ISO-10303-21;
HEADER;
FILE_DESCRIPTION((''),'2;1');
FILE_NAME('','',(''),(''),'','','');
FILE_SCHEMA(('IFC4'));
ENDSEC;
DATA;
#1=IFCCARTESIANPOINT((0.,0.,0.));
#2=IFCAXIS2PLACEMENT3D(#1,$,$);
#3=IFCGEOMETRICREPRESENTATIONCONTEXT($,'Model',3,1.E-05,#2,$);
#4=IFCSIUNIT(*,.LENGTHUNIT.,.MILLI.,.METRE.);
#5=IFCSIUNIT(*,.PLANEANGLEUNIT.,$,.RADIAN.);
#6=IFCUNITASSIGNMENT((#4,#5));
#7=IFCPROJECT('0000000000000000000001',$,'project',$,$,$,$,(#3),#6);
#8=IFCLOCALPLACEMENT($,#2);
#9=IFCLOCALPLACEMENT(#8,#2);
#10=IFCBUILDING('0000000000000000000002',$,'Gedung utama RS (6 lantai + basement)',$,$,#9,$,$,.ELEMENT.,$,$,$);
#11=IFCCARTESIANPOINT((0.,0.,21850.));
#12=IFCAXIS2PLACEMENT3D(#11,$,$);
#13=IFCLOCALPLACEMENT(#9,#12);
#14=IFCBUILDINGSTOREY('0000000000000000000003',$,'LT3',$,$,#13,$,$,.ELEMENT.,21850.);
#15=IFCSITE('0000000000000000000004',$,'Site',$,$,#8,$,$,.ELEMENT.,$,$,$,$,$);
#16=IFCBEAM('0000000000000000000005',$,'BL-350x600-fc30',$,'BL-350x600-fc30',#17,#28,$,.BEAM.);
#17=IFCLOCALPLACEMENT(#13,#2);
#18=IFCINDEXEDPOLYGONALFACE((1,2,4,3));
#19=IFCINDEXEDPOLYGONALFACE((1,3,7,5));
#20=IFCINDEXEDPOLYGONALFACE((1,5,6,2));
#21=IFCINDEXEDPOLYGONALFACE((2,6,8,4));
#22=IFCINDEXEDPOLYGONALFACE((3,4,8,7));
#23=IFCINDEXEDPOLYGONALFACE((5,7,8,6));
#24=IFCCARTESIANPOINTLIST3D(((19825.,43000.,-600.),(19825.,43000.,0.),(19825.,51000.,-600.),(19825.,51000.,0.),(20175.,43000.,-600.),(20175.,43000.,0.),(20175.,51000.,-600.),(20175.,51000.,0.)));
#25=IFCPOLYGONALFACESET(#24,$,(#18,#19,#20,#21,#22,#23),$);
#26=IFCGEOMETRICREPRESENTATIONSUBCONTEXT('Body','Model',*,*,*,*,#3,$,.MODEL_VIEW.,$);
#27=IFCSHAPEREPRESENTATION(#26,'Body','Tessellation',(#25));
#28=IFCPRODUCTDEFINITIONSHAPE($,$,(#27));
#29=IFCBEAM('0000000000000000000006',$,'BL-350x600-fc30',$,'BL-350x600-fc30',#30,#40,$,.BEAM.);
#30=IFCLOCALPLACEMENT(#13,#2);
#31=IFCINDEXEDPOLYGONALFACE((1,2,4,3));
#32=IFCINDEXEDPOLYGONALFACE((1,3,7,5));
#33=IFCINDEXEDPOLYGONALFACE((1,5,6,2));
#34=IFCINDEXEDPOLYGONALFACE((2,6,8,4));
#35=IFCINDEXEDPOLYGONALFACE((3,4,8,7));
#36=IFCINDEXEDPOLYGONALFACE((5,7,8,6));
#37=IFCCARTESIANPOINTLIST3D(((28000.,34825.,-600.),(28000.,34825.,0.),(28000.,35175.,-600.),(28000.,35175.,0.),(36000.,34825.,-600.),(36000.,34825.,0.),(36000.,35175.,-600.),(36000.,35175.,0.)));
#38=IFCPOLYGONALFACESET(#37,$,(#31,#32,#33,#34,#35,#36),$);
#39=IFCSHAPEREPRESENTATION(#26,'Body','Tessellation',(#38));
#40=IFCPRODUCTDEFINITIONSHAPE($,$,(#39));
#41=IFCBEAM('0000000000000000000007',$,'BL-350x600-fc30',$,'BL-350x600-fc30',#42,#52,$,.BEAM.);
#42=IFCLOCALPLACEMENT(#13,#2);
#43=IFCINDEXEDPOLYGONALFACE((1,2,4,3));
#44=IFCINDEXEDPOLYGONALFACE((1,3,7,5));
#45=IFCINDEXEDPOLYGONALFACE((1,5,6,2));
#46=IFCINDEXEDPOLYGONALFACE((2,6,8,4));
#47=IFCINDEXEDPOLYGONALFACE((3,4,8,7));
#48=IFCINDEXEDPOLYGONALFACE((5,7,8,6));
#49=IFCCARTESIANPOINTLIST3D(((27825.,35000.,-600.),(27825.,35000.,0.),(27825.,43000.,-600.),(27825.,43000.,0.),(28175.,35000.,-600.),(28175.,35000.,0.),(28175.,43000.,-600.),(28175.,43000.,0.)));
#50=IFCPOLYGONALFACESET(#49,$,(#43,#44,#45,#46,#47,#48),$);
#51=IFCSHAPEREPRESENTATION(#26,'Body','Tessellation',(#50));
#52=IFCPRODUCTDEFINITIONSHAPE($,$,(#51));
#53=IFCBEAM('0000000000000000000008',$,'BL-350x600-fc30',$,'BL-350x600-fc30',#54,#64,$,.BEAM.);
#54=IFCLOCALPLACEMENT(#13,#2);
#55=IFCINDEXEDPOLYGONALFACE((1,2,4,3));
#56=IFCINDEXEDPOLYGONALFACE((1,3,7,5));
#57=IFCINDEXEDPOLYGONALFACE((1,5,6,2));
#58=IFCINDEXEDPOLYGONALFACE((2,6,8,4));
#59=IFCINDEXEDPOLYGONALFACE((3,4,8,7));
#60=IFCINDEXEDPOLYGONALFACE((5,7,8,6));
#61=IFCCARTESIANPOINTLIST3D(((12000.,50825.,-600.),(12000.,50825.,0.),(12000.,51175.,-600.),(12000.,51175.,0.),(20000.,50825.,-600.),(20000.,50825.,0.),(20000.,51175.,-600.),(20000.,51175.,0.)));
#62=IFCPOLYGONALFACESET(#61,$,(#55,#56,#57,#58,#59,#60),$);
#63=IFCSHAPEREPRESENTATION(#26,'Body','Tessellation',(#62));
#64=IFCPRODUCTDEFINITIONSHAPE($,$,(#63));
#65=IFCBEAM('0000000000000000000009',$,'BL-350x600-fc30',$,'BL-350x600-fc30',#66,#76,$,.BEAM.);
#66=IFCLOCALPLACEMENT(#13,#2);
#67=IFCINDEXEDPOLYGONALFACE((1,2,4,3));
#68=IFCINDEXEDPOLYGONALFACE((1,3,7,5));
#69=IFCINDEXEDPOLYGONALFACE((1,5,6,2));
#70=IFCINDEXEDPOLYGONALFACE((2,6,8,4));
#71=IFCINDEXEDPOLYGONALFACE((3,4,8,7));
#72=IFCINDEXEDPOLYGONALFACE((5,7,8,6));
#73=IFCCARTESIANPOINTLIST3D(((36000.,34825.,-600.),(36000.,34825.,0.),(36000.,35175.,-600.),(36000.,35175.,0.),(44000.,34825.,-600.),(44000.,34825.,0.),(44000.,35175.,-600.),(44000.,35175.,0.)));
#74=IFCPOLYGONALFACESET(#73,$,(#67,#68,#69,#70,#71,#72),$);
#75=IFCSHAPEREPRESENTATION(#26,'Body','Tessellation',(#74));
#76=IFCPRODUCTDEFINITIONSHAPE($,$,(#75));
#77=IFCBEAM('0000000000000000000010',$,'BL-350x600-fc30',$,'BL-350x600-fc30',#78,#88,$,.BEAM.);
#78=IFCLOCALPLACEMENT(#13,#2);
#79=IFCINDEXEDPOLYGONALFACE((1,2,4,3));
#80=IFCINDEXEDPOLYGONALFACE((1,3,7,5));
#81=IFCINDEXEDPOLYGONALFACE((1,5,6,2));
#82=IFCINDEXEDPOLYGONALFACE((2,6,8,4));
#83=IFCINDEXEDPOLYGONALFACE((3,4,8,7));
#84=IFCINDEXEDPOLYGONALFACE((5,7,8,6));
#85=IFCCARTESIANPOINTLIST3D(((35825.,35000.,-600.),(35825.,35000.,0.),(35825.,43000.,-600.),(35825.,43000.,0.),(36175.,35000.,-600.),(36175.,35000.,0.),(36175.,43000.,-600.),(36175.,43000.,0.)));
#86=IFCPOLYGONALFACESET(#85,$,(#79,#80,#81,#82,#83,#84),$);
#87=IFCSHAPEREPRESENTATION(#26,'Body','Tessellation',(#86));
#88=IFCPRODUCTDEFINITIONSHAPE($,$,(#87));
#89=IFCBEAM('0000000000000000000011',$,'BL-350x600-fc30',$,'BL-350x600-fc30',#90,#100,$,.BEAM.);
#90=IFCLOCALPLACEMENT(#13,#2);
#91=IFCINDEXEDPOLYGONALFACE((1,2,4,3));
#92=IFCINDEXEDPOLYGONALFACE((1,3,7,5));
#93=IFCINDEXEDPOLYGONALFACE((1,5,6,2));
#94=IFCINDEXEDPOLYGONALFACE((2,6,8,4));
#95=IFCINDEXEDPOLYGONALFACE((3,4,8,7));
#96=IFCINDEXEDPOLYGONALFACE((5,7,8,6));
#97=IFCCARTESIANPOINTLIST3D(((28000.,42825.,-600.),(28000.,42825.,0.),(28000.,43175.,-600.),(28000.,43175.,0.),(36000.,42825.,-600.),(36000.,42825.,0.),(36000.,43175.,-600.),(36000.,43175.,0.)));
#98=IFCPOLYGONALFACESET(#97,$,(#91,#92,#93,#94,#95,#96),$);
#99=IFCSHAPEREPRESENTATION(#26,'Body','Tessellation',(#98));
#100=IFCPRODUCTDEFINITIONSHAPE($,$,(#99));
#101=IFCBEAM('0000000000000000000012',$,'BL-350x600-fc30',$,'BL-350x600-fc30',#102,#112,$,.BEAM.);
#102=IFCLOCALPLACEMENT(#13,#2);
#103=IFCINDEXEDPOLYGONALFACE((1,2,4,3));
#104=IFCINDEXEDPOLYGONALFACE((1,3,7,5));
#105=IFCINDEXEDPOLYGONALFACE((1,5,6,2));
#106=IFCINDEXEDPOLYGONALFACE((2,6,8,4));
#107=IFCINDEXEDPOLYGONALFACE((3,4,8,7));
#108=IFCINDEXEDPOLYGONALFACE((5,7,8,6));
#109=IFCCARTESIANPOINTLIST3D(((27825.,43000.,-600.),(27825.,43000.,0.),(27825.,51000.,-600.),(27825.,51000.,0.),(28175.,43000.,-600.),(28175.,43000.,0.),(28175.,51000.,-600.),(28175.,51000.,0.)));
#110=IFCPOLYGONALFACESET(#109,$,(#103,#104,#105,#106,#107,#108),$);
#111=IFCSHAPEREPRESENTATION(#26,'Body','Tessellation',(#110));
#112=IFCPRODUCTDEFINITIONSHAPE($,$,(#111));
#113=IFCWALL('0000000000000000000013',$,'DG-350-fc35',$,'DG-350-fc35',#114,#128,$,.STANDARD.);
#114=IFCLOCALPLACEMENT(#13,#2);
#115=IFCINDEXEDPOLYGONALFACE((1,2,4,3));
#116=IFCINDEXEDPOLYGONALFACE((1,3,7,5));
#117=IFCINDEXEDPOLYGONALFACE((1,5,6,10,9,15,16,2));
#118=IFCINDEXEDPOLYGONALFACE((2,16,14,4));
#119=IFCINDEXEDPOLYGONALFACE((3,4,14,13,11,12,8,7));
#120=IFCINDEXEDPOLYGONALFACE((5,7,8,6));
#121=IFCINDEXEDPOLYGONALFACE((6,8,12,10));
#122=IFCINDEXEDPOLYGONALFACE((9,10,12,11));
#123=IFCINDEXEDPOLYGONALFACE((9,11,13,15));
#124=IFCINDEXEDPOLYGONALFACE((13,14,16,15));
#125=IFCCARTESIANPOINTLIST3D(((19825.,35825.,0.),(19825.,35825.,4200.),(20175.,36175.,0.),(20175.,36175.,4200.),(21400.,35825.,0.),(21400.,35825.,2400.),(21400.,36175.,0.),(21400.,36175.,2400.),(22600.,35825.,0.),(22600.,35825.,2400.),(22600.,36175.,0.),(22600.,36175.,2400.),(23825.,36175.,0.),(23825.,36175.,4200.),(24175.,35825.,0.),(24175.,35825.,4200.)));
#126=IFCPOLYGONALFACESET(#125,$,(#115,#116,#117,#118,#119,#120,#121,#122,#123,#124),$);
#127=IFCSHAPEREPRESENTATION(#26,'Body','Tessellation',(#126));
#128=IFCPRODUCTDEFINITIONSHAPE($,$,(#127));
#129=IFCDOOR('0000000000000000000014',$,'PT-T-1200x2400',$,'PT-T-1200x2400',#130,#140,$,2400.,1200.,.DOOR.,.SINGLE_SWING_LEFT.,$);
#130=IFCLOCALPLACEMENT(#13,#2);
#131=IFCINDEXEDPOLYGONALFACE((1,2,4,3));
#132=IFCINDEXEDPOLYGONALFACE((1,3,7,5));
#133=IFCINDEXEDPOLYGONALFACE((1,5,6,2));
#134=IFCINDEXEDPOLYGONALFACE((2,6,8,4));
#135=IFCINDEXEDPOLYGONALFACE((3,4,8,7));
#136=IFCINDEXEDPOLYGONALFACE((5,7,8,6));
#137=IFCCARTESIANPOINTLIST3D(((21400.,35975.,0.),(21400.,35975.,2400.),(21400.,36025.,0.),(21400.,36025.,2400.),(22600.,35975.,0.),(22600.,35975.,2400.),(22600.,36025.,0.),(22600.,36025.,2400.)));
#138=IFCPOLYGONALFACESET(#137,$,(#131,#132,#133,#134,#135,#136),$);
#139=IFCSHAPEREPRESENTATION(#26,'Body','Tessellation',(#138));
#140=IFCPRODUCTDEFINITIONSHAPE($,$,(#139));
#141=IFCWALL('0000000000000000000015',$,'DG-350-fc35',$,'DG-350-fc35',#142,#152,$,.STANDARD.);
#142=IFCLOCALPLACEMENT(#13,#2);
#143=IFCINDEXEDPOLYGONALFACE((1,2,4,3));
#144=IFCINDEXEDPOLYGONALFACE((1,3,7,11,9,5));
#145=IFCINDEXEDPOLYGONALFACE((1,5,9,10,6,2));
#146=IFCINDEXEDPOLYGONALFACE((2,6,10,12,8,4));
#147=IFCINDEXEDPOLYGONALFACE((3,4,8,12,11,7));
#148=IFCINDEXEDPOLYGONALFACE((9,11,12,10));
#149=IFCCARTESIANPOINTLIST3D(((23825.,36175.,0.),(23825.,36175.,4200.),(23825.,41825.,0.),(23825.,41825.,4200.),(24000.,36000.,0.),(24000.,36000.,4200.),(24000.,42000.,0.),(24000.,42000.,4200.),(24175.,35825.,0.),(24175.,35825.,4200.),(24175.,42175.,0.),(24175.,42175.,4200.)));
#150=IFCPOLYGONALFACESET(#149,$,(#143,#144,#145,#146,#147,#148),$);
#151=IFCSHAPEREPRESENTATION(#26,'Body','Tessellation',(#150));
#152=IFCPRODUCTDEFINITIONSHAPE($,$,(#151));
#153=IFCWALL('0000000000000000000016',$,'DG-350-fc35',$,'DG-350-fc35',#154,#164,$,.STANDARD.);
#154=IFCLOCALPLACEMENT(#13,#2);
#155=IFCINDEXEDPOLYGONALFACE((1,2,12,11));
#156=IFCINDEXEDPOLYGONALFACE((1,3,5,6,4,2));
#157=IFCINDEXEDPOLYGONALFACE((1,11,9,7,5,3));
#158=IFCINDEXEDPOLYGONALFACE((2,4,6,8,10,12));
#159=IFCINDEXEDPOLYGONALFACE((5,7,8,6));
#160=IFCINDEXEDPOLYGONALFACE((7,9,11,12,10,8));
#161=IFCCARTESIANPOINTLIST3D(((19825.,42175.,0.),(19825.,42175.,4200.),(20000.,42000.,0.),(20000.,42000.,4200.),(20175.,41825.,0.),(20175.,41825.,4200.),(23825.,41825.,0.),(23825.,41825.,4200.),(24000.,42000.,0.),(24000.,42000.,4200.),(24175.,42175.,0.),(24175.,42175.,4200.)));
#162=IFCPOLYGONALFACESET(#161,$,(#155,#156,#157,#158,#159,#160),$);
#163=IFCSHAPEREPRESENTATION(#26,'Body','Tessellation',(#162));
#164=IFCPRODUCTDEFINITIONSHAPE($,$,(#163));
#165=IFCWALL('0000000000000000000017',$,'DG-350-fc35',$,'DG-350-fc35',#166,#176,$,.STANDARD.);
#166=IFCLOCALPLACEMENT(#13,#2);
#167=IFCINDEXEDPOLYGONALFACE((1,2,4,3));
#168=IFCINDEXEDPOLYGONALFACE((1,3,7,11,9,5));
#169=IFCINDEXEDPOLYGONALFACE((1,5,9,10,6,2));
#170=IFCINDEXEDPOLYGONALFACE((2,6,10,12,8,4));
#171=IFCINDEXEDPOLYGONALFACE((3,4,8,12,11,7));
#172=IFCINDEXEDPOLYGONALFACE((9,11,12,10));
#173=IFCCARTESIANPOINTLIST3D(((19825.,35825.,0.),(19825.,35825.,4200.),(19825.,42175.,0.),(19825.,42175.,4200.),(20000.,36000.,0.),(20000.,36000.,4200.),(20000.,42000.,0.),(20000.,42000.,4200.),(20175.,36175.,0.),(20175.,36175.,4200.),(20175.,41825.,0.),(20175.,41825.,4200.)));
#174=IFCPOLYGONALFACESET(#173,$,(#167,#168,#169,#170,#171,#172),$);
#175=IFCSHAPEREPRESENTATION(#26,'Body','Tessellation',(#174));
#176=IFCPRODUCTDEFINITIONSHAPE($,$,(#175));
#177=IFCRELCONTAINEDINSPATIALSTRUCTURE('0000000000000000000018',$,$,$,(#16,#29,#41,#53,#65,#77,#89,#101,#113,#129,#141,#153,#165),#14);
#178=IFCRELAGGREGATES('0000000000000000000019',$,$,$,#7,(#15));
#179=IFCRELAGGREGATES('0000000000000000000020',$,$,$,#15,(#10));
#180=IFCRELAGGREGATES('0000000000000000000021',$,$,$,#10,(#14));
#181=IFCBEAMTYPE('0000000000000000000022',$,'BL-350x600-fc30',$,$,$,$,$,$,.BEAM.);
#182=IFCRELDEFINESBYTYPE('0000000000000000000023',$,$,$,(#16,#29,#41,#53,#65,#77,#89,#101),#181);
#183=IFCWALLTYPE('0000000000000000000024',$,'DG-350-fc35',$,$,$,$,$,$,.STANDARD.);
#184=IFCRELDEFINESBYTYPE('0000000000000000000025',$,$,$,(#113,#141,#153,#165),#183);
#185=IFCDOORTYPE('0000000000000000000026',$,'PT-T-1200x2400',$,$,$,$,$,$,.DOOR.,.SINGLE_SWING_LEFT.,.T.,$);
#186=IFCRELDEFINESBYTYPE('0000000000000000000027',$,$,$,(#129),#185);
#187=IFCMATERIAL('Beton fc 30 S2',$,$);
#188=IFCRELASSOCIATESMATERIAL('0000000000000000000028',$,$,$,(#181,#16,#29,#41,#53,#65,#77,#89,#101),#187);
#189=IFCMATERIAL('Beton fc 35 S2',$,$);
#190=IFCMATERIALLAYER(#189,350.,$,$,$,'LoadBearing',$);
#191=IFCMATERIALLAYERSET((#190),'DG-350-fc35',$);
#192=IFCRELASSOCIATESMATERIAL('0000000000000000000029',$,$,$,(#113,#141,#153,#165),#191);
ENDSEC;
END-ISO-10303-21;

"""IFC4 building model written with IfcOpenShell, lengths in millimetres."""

from ifc_helpers import new_model, si_unit, frame, frame_2d, origin, origin_2d, place, context, subcontext, project, spatial, polyline, rectangle, outline, extrude, material, layer, layer_set, layer_usage, material_profile, profile_set, profile_usage, type_object, element, fill, save


model = new_model("IFC4")

# Units and contexts
model_context = context("Model", 3, precision=1e-05, world=origin())
body_context = subcontext(model_context, "Body", "Model", "MODEL_VIEW")
ifc_project = project(units=[si_unit("LENGTHUNIT", "METRE", prefix="MILLI"), si_unit("PLANEANGLEUNIT", "RADIAN")], contexts=[model_context])

# Site, building, storey
site_placement = place(None, origin())
site = spatial("IfcSite", under=ifc_project, at=site_placement, Name="Site", CompositionType="ELEMENT")
building_placement = place(site_placement, origin())
building = spatial("IfcBuilding", under=site, at=building_placement, Name="Gedung utama RS (6 lantai + basement)", CompositionType="ELEMENT")
storey_placement = place(building_placement, frame((0.0, 0.0, 21850.0)))
storey = spatial("IfcBuildingStorey", under=building, at=storey_placement, Name="LT3", CompositionType="ELEMENT", Elevation=21850.0)

# Beams
ifc_material_1 = material(Name="Beton fc 30 S2")
ifc_material_profile_1 = material_profile(ifc_material_1, rectangle(XDim=350.0, YDim=600.0, at=origin_2d()), Name="BL-350x600-fc30")
ifc_profile_set_1 = profile_set([ifc_material_profile_1], Name="BL-350x600-fc30")
ifc_profile_usage_1 = profile_usage(ifc_profile_set_1, cardinal=8)
beam_type = type_object("IfcBeamType", Name="BL-350x600-fc30", PredefinedType="BEAM", material=ifc_profile_set_1)
beam_1_placement = place(storey_placement, frame((20000.0, 43000.0, -300.0)))
element("IfcBeam", 1, at=beam_1_placement, inside=storey, type_object=beam_type, material=ifc_profile_usage_1, Name="BL-350x600-fc30", ObjectType="BL-350x600-fc30", PredefinedType="BEAM", context=body_context, shape_type="SweptSolid", body=[
    extrude(rectangle(XDim=350.0, YDim=600.0, at=origin_2d()), frame((0.0, 0.0, 0.0), z_axis=(0.0, 1.0, 0.0), x_axis=(-1.0, 0.0, 0.0)), (0.0, 0.0, 1.0), 8000.0),
])
beam_2_placement = place(storey_placement, frame((28000.0, 35000.0, -300.0)))
element("IfcBeam", 2, at=beam_2_placement, inside=storey, type_object=beam_type, material=ifc_profile_usage_1, Name="BL-350x600-fc30", ObjectType="BL-350x600-fc30", PredefinedType="BEAM", context=body_context, shape_type="SweptSolid", body=[
    extrude(rectangle(XDim=350.0, YDim=600.0, at=origin_2d()), frame((0.0, 0.0, 0.0), z_axis=(1.0, 0.0, 0.0), x_axis=(0.0, 1.0, 0.0)), (0.0, 0.0, 1.0), 8000.0),
])
beam_3_placement = place(storey_placement, frame((28000.0, 35000.0, -300.0)))
element("IfcBeam", 3, at=beam_3_placement, inside=storey, type_object=beam_type, material=ifc_profile_usage_1, Name="BL-350x600-fc30", ObjectType="BL-350x600-fc30", PredefinedType="BEAM", context=body_context, shape_type="SweptSolid", body=[
    extrude(rectangle(XDim=350.0, YDim=600.0, at=origin_2d()), frame((0.0, 0.0, 0.0), z_axis=(0.0, 1.0, 0.0), x_axis=(-1.0, 0.0, 0.0)), (0.0, 0.0, 1.0), 8000.0),
])
for number, where, name in (
    (4, (12000.0, 51000.0, -300.0), "BL-350x600-fc30"),
    (5, (36000.0, 35000.0, -300.0), "BL-350x600-fc30"),
):
    element("IfcBeam", number, at=place(storey_placement, frame(where)), inside=storey, type_object=beam_type, material=ifc_profile_usage_1, Name=name, ObjectType="BL-350x600-fc30", PredefinedType="BEAM", context=body_context, shape_type="SweptSolid", body=[
        extrude(rectangle(XDim=350.0, YDim=600.0, at=origin_2d()), frame((0.0, 0.0, 0.0), z_axis=(1.0, 0.0, 0.0), x_axis=(0.0, 1.0, 0.0)), (0.0, 0.0, 1.0), 8000.0),
    ])
beam_4_placement = place(storey_placement, frame((36000.0, 35000.0, -300.0)))
element("IfcBeam", 6, at=beam_4_placement, inside=storey, type_object=beam_type, material=ifc_profile_usage_1, Name="BL-350x600-fc30", ObjectType="BL-350x600-fc30", PredefinedType="BEAM", context=body_context, shape_type="SweptSolid", body=[
    extrude(rectangle(XDim=350.0, YDim=600.0, at=origin_2d()), frame((0.0, 0.0, 0.0), z_axis=(0.0, 1.0, 0.0), x_axis=(-1.0, 0.0, 0.0)), (0.0, 0.0, 1.0), 8000.0),
])
beam_5_placement = place(storey_placement, frame((28000.0, 43000.0, -300.0)))
element("IfcBeam", 7, at=beam_5_placement, inside=storey, type_object=beam_type, material=ifc_profile_usage_1, Name="BL-350x600-fc30", ObjectType="BL-350x600-fc30", PredefinedType="BEAM", context=body_context, shape_type="SweptSolid", body=[
    extrude(rectangle(XDim=350.0, YDim=600.0, at=origin_2d()), frame((0.0, 0.0, 0.0), z_axis=(1.0, 0.0, 0.0), x_axis=(0.0, 1.0, 0.0)), (0.0, 0.0, 1.0), 8000.0),
])
beam_6_placement = place(storey_placement, frame((28000.0, 43000.0, -300.0)))
element("IfcBeam", 8, at=beam_6_placement, inside=storey, type_object=beam_type, material=ifc_profile_usage_1, Name="BL-350x600-fc30", ObjectType="BL-350x600-fc30", PredefinedType="BEAM", context=body_context, shape_type="SweptSolid", body=[
    extrude(rectangle(XDim=350.0, YDim=600.0, at=origin_2d()), frame((0.0, 0.0, 0.0), z_axis=(0.0, 1.0, 0.0), x_axis=(-1.0, 0.0, 0.0)), (0.0, 0.0, 1.0), 8000.0),
])

# Wall, opening, door
ifc_material_2 = material(Name="Beton fc 35 S2")
ifc_layer = layer(ifc_material_2, 350.0, Category="LoadBearing")
ifc_layer_set = layer_set([ifc_layer], Name="DG-350-fc35")
ifc_layer_usage = layer_usage(ifc_layer_set, "AXIS2", "NEGATIVE", 175.0)
wall_type = type_object("IfcWallType", Name="DG-350-fc35", PredefinedType="STANDARD")
wall_1_placement = place(storey_placement, frame((20000.0, 36000.0, 0.0), z_axis=(0.0, 0.0, 1.0), x_axis=(1.0, 0.0, 0.0)))
wall_1 = element("IfcWall", 9, at=wall_1_placement, inside=storey, type_object=wall_type, material=ifc_layer_usage, Name="DG-350-fc35", ObjectType="DG-350-fc35", PredefinedType="STANDARD", context=body_context, shape_type="SweptSolid", body=[
    extrude(outline(polyline([(-175.0, -175.0), (0.0, 0.0), (175.0, 175.0), (3825.0, 175.0), (4000.0, 0.0), (4175.0, -175.0), (-175.0, -175.0)])), origin(), (0.0, 0.0, 1.0), 4200.0),
])
opening_placement = place(wall_1_placement, frame((1400.0, 0.0, 0.0), z_axis=(0.0, 0.0, 1.0), x_axis=(1.0, 0.0, 0.0)))
opening = element("IfcOpeningElement", 10, at=opening_placement, cuts=wall_1, PredefinedType="OPENING", context=body_context, shape_type="SweptSolid", body=[
    extrude(rectangle(XDim=1200.0, YDim=370.0, at=frame_2d((600.0, 0.0))), origin(), (0.0, 0.0, 1.0), 2400.0),
])
door_type = type_object("IfcDoorType", Name="PT-T-1200x2400", OperationType="SINGLE_SWING_LEFT", ParameterTakesPrecedence=True, PredefinedType="DOOR")
door_placement = place(opening_placement, origin())
door = element("IfcDoor", 11, at=door_placement, inside=storey, type_object=door_type, Name="PT-T-1200x2400", ObjectType="PT-T-1200x2400", OperationType="SINGLE_SWING_LEFT", OverallHeight=2400.0, OverallWidth=1200.0, PredefinedType="DOOR", context=body_context, shape_type="SweptSolid", body=[
    extrude(rectangle(XDim=1200.0, YDim=50.0, at=frame_2d((600.0, 0.0))), origin(), (0.0, 0.0, 1.0), 2400.0),
])
fill(opening, door)

# Walls
wall_2_placement = place(storey_placement, frame((24000.0, 36000.0, 0.0), z_axis=(0.0, 0.0, 1.0), x_axis=(0.0, 1.0, 0.0)))
element("IfcWall", 12, at=wall_2_placement, inside=storey, type_object=wall_type, material=ifc_layer_usage, Name="DG-350-fc35", ObjectType="DG-350-fc35", PredefinedType="STANDARD", context=body_context, shape_type="SweptSolid", body=[
    extrude(outline(polyline([(-175.0, -175.0), (0.0, 0.0), (175.0, 175.0), (5825.0, 175.0), (6000.0, 0.0), (6175.0, -175.0), (-175.0, -175.0)])), origin(), (0.0, 0.0, 1.0), 4200.0),
])
wall_3_placement = place(storey_placement, frame((24000.0, 42000.0, 0.0), z_axis=(0.0, 0.0, 1.0), x_axis=(-1.0, 0.0, 0.0)))
element("IfcWall", 13, at=wall_3_placement, inside=storey, type_object=wall_type, material=ifc_layer_usage, Name="DG-350-fc35", ObjectType="DG-350-fc35", PredefinedType="STANDARD", context=body_context, shape_type="SweptSolid", body=[
    extrude(outline(polyline([(-175.0, -175.0), (0.0, 0.0), (175.0, 175.0), (3825.0, 175.0), (4000.0, 0.0), (4175.0, -175.0), (-175.0, -175.0)])), origin(), (0.0, 0.0, 1.0), 4200.0),
])
wall_4_placement = place(storey_placement, frame((20000.0, 42000.0, 0.0), z_axis=(0.0, 0.0, 1.0), x_axis=(0.0, -1.0, 0.0)))
element("IfcWall", 14, at=wall_4_placement, inside=storey, type_object=wall_type, material=ifc_layer_usage, Name="DG-350-fc35", ObjectType="DG-350-fc35", PredefinedType="STANDARD", context=body_context, shape_type="SweptSolid", body=[
    extrude(outline(polyline([(-175.0, -175.0), (0.0, 0.0), (175.0, 175.0), (5825.0, 175.0), (6000.0, 0.0), (6175.0, -175.0), (-175.0, -175.0)])), origin(), (0.0, 0.0, 1.0), 4200.0),
])

save(model, "model.ifc")
